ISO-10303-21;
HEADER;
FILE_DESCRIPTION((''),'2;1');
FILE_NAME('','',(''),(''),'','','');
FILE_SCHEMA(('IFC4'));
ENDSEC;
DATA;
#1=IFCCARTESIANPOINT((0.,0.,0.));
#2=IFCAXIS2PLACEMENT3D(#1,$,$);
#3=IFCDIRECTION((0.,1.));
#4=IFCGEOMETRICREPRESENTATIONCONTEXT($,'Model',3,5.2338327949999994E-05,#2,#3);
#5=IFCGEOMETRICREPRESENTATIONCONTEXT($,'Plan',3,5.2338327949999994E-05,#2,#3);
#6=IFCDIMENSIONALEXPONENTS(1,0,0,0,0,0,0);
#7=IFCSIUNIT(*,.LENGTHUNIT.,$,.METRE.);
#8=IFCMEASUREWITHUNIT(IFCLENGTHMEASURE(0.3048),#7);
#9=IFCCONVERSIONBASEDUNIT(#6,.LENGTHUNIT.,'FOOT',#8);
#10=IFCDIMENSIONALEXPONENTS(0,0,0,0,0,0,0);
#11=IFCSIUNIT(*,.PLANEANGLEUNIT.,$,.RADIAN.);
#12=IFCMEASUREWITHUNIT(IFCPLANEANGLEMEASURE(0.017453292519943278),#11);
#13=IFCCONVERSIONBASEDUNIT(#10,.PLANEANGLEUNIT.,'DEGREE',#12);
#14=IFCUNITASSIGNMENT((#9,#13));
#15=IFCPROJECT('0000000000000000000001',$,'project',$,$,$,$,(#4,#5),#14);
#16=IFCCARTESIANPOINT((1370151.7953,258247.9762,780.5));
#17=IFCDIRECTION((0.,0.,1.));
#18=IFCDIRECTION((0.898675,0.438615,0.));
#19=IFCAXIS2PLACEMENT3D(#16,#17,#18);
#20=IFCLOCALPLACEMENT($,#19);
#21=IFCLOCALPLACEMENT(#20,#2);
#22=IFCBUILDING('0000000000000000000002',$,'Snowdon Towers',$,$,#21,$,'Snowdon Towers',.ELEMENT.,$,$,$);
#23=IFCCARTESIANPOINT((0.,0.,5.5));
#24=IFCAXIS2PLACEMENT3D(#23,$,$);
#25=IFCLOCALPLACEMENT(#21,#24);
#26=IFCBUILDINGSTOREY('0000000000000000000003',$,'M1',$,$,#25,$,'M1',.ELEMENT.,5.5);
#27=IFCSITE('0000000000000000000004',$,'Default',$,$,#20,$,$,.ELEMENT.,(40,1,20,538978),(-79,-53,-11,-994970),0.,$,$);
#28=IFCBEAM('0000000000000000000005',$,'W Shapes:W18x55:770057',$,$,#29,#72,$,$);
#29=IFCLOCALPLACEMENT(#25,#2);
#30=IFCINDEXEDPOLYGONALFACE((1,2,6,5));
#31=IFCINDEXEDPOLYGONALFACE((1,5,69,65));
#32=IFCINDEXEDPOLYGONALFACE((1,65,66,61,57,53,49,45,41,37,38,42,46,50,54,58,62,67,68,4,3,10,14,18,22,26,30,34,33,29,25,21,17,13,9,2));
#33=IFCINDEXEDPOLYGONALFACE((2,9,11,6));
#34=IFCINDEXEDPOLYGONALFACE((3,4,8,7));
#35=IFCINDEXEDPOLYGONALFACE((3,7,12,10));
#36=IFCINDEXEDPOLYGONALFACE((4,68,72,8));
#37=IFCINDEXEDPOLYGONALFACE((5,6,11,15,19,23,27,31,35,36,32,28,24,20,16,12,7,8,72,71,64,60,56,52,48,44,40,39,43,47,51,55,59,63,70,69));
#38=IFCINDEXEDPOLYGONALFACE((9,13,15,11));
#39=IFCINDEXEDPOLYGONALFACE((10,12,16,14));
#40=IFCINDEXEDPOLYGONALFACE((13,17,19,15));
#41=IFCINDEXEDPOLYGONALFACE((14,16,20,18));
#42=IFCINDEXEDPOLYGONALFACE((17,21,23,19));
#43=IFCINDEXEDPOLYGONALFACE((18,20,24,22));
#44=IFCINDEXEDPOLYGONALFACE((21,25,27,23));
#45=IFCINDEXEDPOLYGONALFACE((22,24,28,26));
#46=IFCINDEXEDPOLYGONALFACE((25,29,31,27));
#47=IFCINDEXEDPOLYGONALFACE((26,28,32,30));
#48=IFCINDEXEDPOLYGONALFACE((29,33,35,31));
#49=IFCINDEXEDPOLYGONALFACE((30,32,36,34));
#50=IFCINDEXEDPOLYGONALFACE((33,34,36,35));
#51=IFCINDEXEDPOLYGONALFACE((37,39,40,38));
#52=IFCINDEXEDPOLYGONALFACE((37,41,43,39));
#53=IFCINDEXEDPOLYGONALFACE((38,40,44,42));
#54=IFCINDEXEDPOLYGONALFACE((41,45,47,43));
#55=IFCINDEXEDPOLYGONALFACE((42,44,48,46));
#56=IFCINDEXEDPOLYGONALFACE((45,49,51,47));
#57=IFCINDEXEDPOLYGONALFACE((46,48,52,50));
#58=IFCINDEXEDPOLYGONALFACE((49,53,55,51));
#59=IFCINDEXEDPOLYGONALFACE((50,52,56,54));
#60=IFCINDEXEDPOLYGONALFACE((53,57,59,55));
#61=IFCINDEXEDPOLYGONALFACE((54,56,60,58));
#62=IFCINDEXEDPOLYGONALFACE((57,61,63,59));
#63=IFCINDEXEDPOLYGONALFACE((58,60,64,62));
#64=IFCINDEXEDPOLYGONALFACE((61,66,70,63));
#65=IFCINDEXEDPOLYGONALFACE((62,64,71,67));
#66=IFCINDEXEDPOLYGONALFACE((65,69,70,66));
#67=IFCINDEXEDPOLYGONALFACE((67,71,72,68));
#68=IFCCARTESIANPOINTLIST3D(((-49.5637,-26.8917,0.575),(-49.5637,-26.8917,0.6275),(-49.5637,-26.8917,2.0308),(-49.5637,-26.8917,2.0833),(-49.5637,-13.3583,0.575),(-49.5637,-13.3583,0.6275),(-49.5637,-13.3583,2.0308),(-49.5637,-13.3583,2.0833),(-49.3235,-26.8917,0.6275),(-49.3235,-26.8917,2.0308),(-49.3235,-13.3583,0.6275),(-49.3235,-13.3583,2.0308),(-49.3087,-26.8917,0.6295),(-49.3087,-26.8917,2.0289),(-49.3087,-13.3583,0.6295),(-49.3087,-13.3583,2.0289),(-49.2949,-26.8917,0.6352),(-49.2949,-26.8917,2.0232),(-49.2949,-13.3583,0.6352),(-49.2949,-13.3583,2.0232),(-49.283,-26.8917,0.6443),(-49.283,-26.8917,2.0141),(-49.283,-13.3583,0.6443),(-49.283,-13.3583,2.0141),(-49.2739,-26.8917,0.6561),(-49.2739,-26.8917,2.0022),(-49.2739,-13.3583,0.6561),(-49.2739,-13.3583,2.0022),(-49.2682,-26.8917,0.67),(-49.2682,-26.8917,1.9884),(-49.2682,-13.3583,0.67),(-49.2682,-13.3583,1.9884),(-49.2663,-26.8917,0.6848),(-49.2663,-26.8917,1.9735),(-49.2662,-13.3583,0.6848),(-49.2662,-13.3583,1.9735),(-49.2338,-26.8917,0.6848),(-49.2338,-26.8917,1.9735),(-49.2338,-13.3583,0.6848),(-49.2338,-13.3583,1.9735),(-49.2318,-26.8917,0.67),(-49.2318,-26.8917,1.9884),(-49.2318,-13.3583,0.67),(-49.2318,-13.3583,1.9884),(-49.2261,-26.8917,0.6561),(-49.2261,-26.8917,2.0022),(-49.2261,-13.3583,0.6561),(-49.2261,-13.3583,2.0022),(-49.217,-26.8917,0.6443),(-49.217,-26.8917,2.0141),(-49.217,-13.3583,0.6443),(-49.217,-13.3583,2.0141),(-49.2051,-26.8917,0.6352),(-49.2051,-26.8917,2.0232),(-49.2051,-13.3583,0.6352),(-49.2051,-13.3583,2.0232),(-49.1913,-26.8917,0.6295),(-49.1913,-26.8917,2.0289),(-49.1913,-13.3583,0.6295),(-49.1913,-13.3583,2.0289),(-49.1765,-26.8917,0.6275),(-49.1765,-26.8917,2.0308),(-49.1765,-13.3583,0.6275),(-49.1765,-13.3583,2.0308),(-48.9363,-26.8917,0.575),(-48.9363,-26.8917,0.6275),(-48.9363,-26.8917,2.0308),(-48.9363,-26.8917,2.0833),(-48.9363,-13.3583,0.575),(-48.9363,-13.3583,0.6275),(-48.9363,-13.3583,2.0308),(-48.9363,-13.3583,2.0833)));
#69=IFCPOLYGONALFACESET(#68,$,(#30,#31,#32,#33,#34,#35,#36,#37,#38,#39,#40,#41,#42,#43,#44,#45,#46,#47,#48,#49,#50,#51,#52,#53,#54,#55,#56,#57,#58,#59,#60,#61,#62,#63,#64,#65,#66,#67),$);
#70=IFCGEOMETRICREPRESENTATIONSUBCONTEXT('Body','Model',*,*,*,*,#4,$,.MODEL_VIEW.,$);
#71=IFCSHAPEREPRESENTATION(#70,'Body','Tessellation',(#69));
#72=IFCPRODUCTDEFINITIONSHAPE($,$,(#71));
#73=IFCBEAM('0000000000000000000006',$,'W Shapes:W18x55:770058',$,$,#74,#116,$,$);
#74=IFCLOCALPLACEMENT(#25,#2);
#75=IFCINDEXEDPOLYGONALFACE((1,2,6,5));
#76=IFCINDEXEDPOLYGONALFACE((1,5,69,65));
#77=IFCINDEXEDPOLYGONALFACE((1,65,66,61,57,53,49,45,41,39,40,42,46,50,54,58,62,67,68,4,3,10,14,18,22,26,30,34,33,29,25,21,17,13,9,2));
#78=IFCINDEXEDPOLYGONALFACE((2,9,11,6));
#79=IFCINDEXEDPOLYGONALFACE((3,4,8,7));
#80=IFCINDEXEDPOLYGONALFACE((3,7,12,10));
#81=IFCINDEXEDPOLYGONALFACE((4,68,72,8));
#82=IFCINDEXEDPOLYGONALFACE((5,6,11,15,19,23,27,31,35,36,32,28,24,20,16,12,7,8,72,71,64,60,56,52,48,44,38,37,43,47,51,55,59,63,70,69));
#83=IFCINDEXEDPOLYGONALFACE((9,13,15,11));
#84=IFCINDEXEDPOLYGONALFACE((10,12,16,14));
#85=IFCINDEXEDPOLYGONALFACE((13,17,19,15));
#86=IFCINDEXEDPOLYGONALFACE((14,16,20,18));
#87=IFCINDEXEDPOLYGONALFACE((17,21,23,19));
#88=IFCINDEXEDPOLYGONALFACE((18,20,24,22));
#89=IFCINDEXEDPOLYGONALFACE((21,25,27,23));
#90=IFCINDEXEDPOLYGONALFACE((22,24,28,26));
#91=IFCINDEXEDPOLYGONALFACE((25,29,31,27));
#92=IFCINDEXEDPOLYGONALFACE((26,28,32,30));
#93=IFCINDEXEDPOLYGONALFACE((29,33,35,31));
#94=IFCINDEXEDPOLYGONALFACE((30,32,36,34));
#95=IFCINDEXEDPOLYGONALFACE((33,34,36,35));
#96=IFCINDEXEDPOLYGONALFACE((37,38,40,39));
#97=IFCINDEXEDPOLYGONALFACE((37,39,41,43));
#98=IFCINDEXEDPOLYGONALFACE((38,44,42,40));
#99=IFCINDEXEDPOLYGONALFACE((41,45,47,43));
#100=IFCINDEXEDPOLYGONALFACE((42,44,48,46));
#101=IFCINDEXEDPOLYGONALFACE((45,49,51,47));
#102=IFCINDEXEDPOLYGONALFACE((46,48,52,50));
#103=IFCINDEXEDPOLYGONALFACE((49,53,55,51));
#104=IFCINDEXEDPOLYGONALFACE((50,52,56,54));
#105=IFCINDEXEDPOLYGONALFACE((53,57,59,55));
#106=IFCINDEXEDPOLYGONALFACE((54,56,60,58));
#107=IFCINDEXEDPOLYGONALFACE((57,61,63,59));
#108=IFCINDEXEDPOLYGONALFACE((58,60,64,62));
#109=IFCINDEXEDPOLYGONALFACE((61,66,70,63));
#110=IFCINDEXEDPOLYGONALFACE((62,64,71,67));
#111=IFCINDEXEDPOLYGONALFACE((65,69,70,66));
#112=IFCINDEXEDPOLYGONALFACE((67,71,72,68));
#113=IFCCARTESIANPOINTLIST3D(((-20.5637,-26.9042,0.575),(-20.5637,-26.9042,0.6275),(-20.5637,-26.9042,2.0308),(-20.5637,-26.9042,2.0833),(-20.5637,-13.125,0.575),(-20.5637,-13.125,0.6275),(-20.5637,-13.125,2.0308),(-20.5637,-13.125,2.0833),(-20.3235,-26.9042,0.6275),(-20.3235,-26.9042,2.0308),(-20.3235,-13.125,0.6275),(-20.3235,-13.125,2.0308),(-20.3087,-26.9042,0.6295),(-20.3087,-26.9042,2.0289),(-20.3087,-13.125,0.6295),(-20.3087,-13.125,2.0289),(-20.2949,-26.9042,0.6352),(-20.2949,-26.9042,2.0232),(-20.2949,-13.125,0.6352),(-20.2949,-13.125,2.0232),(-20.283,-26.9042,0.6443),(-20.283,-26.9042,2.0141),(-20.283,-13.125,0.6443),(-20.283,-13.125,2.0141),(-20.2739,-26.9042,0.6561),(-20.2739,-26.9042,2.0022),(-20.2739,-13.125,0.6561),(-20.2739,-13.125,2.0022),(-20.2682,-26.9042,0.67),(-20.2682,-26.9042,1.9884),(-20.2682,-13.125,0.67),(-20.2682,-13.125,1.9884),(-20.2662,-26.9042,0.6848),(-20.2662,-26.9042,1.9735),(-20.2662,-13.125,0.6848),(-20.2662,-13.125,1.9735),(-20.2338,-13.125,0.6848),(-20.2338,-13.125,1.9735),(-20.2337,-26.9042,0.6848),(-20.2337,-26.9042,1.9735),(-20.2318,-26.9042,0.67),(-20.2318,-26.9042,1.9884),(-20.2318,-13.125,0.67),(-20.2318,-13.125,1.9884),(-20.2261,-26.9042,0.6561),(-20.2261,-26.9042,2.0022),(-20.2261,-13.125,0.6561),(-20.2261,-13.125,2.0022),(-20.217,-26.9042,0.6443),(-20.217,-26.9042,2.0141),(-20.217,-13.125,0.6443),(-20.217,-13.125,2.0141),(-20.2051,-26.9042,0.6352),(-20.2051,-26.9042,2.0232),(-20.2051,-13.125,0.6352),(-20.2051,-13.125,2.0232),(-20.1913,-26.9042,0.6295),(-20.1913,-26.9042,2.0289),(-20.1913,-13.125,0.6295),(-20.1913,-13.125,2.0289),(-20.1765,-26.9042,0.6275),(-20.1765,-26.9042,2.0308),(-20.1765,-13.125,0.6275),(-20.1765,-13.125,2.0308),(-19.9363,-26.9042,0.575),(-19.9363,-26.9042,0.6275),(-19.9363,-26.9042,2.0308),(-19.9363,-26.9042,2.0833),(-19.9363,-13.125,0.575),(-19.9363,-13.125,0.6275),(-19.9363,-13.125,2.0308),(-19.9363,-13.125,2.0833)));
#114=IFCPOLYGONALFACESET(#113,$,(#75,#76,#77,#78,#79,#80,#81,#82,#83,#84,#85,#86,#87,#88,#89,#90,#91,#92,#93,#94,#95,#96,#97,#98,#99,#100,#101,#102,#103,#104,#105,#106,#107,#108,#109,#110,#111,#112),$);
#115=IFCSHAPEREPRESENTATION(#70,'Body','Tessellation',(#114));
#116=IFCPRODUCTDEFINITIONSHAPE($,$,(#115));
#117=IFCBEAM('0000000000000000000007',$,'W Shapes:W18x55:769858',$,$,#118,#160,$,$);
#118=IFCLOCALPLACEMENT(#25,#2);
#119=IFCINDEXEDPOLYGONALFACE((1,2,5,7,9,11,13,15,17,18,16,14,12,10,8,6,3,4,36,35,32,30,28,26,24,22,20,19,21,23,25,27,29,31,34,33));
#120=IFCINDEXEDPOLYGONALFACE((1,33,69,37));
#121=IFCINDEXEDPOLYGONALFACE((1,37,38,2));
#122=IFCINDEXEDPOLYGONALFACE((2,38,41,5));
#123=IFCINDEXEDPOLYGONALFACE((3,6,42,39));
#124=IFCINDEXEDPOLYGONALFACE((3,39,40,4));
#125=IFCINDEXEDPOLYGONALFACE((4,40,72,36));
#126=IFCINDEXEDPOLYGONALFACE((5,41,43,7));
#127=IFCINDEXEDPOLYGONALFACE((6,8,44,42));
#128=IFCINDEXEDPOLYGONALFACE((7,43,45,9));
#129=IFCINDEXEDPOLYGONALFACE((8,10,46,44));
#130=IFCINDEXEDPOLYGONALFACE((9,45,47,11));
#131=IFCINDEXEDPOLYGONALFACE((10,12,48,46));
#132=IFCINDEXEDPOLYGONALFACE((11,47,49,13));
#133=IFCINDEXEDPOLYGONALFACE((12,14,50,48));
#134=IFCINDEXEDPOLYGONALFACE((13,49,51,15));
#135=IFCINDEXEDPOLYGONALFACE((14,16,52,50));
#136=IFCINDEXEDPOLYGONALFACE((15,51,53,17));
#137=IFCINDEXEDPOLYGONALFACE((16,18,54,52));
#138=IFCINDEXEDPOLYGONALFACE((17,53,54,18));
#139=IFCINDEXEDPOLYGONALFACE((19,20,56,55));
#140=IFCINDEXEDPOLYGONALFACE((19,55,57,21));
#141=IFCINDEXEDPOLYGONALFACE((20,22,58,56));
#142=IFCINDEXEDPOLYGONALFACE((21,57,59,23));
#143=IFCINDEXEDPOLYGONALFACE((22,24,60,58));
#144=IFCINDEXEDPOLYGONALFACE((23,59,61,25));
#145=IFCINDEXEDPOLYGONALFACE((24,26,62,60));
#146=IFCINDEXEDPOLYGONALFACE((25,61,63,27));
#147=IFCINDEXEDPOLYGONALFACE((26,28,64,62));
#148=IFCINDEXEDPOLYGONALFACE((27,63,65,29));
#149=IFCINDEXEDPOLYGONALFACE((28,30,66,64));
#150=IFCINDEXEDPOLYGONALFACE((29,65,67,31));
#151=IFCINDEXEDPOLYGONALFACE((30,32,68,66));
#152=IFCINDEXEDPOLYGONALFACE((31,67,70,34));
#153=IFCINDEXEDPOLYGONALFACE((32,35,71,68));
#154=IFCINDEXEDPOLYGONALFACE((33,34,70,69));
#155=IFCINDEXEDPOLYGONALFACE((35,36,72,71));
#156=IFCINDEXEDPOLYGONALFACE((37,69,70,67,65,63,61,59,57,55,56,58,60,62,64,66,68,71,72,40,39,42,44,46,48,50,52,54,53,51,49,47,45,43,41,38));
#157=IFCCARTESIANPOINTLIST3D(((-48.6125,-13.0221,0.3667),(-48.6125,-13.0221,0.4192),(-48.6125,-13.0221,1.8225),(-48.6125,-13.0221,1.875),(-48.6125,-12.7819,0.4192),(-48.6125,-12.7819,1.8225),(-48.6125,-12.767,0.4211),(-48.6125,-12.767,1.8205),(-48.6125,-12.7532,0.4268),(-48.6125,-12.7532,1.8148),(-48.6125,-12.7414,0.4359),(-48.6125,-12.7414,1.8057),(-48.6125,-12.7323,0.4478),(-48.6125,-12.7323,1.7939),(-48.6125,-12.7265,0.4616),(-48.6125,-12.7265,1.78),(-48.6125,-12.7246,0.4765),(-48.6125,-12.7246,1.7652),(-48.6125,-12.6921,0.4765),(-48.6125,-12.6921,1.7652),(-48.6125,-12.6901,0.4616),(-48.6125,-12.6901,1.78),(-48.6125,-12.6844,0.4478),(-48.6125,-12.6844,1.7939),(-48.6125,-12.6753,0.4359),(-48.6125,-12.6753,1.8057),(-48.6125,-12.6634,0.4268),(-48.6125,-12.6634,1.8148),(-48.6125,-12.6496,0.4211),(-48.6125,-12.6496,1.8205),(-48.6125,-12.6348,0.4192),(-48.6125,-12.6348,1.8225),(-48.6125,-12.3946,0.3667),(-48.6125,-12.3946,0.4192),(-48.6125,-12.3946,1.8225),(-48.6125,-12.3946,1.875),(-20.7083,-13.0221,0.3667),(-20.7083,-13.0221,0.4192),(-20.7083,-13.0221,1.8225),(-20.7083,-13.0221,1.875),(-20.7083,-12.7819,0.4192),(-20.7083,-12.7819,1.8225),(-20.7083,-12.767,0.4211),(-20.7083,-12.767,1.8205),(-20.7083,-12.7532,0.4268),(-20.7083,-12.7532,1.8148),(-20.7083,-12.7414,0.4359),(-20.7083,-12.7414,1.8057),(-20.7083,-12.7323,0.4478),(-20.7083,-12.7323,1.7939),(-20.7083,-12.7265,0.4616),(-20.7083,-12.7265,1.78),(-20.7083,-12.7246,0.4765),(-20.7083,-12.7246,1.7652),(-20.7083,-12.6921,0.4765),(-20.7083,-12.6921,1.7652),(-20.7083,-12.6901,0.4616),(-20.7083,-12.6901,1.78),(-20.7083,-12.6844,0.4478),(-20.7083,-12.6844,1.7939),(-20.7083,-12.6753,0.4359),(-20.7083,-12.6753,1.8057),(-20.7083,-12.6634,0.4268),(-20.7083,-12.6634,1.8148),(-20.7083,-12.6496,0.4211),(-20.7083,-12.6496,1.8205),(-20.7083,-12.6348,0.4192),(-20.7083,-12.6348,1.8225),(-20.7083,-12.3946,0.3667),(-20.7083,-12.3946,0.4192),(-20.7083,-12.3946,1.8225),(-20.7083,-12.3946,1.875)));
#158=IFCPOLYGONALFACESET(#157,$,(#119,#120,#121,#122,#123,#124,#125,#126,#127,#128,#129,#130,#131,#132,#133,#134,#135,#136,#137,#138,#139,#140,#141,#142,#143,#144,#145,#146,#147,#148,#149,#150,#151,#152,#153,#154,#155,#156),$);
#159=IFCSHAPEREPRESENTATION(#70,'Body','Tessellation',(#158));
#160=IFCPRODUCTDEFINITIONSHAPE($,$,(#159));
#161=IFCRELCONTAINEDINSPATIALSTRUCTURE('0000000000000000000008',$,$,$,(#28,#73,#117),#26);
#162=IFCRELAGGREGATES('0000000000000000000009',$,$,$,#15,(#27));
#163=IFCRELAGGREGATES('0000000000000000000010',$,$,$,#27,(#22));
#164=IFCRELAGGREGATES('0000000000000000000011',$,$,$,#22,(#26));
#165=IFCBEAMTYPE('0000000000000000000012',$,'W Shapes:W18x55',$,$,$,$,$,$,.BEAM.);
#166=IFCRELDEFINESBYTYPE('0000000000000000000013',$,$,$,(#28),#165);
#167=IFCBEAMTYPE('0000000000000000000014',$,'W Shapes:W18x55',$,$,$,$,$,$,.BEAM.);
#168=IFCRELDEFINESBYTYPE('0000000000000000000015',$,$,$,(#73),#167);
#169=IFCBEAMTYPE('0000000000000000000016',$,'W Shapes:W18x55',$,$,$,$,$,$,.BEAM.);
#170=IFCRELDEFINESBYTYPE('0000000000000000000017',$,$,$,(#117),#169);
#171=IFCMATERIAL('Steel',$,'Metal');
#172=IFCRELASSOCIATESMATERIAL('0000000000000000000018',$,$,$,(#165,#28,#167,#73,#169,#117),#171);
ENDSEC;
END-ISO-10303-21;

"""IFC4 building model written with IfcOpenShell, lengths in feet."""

from ifc_helpers import new_model, entity, si_unit, converted_unit, direction, frame, origin, place, context, subcontext, project, spatial, line, arc, indexed_curve, outline, extrude, source, transform, mapped, material, type_object, type_shapes, element, save


model = new_model("IFC4")

# Units and contexts
model_context = context("Model", 3, precision=5.2338327949999994e-05, world=origin(), true_north=direction((0.0, 1.0)))
plan_context = context("Plan", 3, precision=5.2338327949999994e-05, world=origin(), true_north=direction((0.0, 1.0)))
body_context = subcontext(model_context, "Body", "Model", "MODEL_VIEW")
ifc_project = project(units=[converted_unit("LENGTHUNIT", "FOOT", entity("IfcLengthMeasure", 0.3048), si_unit("LENGTHUNIT", "METRE"), dimensions=[1, 0, 0, 0, 0, 0, 0]), converted_unit("PLANEANGLEUNIT", "DEGREE", entity("IfcPlaneAngleMeasure", 0.017453292519943278), si_unit("PLANEANGLEUNIT", "RADIAN"), dimensions=[0, 0, 0, 0, 0, 0, 0])], contexts=[model_context, plan_context])

# Site, building, storey
site_placement = place(None, frame((1370151.7953, 258247.9762, 780.5), z_axis=(0.0, 0.0, 1.0), x_axis=(0.898675, 0.438615, 0.0)))
site = spatial("IfcSite", under=ifc_project, at=site_placement, Name="Default", CompositionType="ELEMENT", RefLatitude=(40, 1, 20, 538978), RefLongitude=(-79, -53, -11, -994970), RefElevation=0.0)
building_placement = place(site_placement, origin())
building = spatial("IfcBuilding", under=site, at=building_placement, Name="Snowdon Towers", LongName="Snowdon Towers", CompositionType="ELEMENT")
storey_placement = place(building_placement, frame((0.0, 0.0, 5.5)))
storey = spatial("IfcBuildingStorey", under=building, at=storey_placement, Name="M1", LongName="M1", CompositionType="ELEMENT", Elevation=5.5)

# Beams
ifc_material_1 = material(Name="Steel", Category="Metal")
beam_type_1 = type_object("IfcBeamType", Name="W Shapes:W18x55", PredefinedType="BEAM", material=ifc_material_1)
shared_shape_1 = source(origin(), body_context, "Body", "SweptSolid", [
    extrude(outline(indexed_curve([(-0.7542, -0.3138), (-0.7017, -0.3138), (-0.7017, -0.0735), (-0.6849, -0.033), (-0.6444, -0.0162), (0.6444, -0.0162), (0.6849, -0.033), (0.7017, -0.0735), (0.7017, -0.3138), (0.7542, -0.3138), (0.7542, 0.3138), (0.7017, 0.3138), (0.7017, 0.0735), (0.6849, 0.033), (0.6444, 0.0163), (-0.6444, 0.0163), (-0.6849, 0.033), (-0.7017, 0.0735), (-0.7017, 0.3137), (-0.7542, 0.3137)], segments=[line(1, 2, 3), arc(3, 4, 5), line(5, 6), arc(6, 7, 8), line(8, 9, 10, 11, 12, 13), arc(13, 14, 15), line(15, 16), arc(16, 17, 18), line(18, 19, 20, 1)], self_intersect=False)), frame((-6.9958, 0.0, 0.0), z_axis=(1.0, 0.0, 0.0), x_axis=(0.0, 0.0, -1.0)), (0.0, 0.0, 1.0), 13.5333),
])
type_shapes(beam_type_1, [shared_shape_1])
beam_1_placement = place(storey_placement, frame((-49.25, -20.3542, 1.3292), z_axis=(0.0, 0.0, 1.0), x_axis=(0.0, -1.0, 0.0)))
element("IfcBeam", 1, at=beam_1_placement, inside=storey, type_object=beam_type_1, material=ifc_material_1, Name="W Shapes:W18x55:770057", context=body_context, shape_type="MappedRepresentation", body=[
    mapped(shared_shape_1, transform((0.0, 0.0, 0.0), scale=1.0)),
])
beam_type_2 = type_object("IfcBeamType", Name="W Shapes:W18x55", PredefinedType="BEAM", material=ifc_material_1)
shared_shape_2 = source(origin(), body_context, "Body", "SweptSolid", [
    extrude(outline(indexed_curve([(-0.7542, -0.3138), (-0.7017, -0.3138), (-0.7017, -0.0735), (-0.6849, -0.033), (-0.6444, -0.0162), (0.6444, -0.0162), (0.6849, -0.033), (0.7017, -0.0735), (0.7017, -0.3138), (0.7542, -0.3138), (0.7542, 0.3138), (0.7017, 0.3138), (0.7017, 0.0735), (0.6849, 0.033), (0.6444, 0.0163), (-0.6444, 0.0163), (-0.6849, 0.033), (-0.7017, 0.0735), (-0.7017, 0.3137), (-0.7542, 0.3137)], segments=[line(1, 2, 3), arc(3, 4, 5), line(5, 6), arc(6, 7, 8), line(8, 9, 10, 11, 12, 13), arc(13, 14, 15), line(15, 16), arc(16, 17, 18), line(18, 19, 20, 1)], self_intersect=False)), frame((-7.2292, 0.0, 0.0), z_axis=(1.0, 0.0, 0.0), x_axis=(0.0, 0.0, -1.0)), (0.0, 0.0, 1.0), 13.7792),
])
type_shapes(beam_type_2, [shared_shape_2])
beam_2_placement = place(storey_placement, frame((-20.25, -20.3542, 1.3292), z_axis=(0.0, 0.0, 1.0), x_axis=(0.0, -1.0, 0.0)))
element("IfcBeam", 2, at=beam_2_placement, inside=storey, type_object=beam_type_2, material=ifc_material_1, Name="W Shapes:W18x55:770058", context=body_context, shape_type="MappedRepresentation", body=[
    mapped(shared_shape_2, transform((0.0, 0.0, 0.0), scale=1.0)),
])
beam_type_3 = type_object("IfcBeamType", Name="W Shapes:W18x55", PredefinedType="BEAM", material=ifc_material_1)
shared_shape_3 = source(origin(), body_context, "Body", "SweptSolid", [
    extrude(outline(indexed_curve([(-0.7542, -0.3138), (-0.7017, -0.3138), (-0.7017, -0.0735), (-0.6849, -0.033), (-0.6444, -0.0162), (0.6444, -0.0162), (0.6849, -0.033), (0.7017, -0.0735), (0.7017, -0.3138), (0.7542, -0.3138), (0.7542, 0.3138), (0.7017, 0.3138), (0.7017, 0.0735), (0.6849, 0.033), (0.6444, 0.0163), (-0.6444, 0.0163), (-0.6849, 0.033), (-0.7017, 0.0735), (-0.7017, 0.3137), (-0.7542, 0.3137)], segments=[line(1, 2, 3), arc(3, 4, 5), line(5, 6), arc(6, 7, 8), line(8, 9, 10, 11, 12, 13), arc(13, 14, 15), line(15, 16), arc(16, 17, 18), line(18, 19, 20, 1)], self_intersect=False)), frame((-13.8625, 0.0, 0.0), z_axis=(1.0, 0.0, 0.0), x_axis=(0.0, 0.0, -1.0)), (0.0, 0.0, 1.0), 27.9042),
])
type_shapes(beam_type_3, [shared_shape_3])
beam_3_placement = place(storey_placement, frame((-34.75, -12.7083, 1.1208)))
element("IfcBeam", 3, at=beam_3_placement, inside=storey, type_object=beam_type_3, material=ifc_material_1, Name="W Shapes:W18x55:769858", context=body_context, shape_type="MappedRepresentation", body=[
    mapped(shared_shape_3, transform((0.0, 0.0, 0.0), scale=1.0)),
])

save(model, "model.ifc")
